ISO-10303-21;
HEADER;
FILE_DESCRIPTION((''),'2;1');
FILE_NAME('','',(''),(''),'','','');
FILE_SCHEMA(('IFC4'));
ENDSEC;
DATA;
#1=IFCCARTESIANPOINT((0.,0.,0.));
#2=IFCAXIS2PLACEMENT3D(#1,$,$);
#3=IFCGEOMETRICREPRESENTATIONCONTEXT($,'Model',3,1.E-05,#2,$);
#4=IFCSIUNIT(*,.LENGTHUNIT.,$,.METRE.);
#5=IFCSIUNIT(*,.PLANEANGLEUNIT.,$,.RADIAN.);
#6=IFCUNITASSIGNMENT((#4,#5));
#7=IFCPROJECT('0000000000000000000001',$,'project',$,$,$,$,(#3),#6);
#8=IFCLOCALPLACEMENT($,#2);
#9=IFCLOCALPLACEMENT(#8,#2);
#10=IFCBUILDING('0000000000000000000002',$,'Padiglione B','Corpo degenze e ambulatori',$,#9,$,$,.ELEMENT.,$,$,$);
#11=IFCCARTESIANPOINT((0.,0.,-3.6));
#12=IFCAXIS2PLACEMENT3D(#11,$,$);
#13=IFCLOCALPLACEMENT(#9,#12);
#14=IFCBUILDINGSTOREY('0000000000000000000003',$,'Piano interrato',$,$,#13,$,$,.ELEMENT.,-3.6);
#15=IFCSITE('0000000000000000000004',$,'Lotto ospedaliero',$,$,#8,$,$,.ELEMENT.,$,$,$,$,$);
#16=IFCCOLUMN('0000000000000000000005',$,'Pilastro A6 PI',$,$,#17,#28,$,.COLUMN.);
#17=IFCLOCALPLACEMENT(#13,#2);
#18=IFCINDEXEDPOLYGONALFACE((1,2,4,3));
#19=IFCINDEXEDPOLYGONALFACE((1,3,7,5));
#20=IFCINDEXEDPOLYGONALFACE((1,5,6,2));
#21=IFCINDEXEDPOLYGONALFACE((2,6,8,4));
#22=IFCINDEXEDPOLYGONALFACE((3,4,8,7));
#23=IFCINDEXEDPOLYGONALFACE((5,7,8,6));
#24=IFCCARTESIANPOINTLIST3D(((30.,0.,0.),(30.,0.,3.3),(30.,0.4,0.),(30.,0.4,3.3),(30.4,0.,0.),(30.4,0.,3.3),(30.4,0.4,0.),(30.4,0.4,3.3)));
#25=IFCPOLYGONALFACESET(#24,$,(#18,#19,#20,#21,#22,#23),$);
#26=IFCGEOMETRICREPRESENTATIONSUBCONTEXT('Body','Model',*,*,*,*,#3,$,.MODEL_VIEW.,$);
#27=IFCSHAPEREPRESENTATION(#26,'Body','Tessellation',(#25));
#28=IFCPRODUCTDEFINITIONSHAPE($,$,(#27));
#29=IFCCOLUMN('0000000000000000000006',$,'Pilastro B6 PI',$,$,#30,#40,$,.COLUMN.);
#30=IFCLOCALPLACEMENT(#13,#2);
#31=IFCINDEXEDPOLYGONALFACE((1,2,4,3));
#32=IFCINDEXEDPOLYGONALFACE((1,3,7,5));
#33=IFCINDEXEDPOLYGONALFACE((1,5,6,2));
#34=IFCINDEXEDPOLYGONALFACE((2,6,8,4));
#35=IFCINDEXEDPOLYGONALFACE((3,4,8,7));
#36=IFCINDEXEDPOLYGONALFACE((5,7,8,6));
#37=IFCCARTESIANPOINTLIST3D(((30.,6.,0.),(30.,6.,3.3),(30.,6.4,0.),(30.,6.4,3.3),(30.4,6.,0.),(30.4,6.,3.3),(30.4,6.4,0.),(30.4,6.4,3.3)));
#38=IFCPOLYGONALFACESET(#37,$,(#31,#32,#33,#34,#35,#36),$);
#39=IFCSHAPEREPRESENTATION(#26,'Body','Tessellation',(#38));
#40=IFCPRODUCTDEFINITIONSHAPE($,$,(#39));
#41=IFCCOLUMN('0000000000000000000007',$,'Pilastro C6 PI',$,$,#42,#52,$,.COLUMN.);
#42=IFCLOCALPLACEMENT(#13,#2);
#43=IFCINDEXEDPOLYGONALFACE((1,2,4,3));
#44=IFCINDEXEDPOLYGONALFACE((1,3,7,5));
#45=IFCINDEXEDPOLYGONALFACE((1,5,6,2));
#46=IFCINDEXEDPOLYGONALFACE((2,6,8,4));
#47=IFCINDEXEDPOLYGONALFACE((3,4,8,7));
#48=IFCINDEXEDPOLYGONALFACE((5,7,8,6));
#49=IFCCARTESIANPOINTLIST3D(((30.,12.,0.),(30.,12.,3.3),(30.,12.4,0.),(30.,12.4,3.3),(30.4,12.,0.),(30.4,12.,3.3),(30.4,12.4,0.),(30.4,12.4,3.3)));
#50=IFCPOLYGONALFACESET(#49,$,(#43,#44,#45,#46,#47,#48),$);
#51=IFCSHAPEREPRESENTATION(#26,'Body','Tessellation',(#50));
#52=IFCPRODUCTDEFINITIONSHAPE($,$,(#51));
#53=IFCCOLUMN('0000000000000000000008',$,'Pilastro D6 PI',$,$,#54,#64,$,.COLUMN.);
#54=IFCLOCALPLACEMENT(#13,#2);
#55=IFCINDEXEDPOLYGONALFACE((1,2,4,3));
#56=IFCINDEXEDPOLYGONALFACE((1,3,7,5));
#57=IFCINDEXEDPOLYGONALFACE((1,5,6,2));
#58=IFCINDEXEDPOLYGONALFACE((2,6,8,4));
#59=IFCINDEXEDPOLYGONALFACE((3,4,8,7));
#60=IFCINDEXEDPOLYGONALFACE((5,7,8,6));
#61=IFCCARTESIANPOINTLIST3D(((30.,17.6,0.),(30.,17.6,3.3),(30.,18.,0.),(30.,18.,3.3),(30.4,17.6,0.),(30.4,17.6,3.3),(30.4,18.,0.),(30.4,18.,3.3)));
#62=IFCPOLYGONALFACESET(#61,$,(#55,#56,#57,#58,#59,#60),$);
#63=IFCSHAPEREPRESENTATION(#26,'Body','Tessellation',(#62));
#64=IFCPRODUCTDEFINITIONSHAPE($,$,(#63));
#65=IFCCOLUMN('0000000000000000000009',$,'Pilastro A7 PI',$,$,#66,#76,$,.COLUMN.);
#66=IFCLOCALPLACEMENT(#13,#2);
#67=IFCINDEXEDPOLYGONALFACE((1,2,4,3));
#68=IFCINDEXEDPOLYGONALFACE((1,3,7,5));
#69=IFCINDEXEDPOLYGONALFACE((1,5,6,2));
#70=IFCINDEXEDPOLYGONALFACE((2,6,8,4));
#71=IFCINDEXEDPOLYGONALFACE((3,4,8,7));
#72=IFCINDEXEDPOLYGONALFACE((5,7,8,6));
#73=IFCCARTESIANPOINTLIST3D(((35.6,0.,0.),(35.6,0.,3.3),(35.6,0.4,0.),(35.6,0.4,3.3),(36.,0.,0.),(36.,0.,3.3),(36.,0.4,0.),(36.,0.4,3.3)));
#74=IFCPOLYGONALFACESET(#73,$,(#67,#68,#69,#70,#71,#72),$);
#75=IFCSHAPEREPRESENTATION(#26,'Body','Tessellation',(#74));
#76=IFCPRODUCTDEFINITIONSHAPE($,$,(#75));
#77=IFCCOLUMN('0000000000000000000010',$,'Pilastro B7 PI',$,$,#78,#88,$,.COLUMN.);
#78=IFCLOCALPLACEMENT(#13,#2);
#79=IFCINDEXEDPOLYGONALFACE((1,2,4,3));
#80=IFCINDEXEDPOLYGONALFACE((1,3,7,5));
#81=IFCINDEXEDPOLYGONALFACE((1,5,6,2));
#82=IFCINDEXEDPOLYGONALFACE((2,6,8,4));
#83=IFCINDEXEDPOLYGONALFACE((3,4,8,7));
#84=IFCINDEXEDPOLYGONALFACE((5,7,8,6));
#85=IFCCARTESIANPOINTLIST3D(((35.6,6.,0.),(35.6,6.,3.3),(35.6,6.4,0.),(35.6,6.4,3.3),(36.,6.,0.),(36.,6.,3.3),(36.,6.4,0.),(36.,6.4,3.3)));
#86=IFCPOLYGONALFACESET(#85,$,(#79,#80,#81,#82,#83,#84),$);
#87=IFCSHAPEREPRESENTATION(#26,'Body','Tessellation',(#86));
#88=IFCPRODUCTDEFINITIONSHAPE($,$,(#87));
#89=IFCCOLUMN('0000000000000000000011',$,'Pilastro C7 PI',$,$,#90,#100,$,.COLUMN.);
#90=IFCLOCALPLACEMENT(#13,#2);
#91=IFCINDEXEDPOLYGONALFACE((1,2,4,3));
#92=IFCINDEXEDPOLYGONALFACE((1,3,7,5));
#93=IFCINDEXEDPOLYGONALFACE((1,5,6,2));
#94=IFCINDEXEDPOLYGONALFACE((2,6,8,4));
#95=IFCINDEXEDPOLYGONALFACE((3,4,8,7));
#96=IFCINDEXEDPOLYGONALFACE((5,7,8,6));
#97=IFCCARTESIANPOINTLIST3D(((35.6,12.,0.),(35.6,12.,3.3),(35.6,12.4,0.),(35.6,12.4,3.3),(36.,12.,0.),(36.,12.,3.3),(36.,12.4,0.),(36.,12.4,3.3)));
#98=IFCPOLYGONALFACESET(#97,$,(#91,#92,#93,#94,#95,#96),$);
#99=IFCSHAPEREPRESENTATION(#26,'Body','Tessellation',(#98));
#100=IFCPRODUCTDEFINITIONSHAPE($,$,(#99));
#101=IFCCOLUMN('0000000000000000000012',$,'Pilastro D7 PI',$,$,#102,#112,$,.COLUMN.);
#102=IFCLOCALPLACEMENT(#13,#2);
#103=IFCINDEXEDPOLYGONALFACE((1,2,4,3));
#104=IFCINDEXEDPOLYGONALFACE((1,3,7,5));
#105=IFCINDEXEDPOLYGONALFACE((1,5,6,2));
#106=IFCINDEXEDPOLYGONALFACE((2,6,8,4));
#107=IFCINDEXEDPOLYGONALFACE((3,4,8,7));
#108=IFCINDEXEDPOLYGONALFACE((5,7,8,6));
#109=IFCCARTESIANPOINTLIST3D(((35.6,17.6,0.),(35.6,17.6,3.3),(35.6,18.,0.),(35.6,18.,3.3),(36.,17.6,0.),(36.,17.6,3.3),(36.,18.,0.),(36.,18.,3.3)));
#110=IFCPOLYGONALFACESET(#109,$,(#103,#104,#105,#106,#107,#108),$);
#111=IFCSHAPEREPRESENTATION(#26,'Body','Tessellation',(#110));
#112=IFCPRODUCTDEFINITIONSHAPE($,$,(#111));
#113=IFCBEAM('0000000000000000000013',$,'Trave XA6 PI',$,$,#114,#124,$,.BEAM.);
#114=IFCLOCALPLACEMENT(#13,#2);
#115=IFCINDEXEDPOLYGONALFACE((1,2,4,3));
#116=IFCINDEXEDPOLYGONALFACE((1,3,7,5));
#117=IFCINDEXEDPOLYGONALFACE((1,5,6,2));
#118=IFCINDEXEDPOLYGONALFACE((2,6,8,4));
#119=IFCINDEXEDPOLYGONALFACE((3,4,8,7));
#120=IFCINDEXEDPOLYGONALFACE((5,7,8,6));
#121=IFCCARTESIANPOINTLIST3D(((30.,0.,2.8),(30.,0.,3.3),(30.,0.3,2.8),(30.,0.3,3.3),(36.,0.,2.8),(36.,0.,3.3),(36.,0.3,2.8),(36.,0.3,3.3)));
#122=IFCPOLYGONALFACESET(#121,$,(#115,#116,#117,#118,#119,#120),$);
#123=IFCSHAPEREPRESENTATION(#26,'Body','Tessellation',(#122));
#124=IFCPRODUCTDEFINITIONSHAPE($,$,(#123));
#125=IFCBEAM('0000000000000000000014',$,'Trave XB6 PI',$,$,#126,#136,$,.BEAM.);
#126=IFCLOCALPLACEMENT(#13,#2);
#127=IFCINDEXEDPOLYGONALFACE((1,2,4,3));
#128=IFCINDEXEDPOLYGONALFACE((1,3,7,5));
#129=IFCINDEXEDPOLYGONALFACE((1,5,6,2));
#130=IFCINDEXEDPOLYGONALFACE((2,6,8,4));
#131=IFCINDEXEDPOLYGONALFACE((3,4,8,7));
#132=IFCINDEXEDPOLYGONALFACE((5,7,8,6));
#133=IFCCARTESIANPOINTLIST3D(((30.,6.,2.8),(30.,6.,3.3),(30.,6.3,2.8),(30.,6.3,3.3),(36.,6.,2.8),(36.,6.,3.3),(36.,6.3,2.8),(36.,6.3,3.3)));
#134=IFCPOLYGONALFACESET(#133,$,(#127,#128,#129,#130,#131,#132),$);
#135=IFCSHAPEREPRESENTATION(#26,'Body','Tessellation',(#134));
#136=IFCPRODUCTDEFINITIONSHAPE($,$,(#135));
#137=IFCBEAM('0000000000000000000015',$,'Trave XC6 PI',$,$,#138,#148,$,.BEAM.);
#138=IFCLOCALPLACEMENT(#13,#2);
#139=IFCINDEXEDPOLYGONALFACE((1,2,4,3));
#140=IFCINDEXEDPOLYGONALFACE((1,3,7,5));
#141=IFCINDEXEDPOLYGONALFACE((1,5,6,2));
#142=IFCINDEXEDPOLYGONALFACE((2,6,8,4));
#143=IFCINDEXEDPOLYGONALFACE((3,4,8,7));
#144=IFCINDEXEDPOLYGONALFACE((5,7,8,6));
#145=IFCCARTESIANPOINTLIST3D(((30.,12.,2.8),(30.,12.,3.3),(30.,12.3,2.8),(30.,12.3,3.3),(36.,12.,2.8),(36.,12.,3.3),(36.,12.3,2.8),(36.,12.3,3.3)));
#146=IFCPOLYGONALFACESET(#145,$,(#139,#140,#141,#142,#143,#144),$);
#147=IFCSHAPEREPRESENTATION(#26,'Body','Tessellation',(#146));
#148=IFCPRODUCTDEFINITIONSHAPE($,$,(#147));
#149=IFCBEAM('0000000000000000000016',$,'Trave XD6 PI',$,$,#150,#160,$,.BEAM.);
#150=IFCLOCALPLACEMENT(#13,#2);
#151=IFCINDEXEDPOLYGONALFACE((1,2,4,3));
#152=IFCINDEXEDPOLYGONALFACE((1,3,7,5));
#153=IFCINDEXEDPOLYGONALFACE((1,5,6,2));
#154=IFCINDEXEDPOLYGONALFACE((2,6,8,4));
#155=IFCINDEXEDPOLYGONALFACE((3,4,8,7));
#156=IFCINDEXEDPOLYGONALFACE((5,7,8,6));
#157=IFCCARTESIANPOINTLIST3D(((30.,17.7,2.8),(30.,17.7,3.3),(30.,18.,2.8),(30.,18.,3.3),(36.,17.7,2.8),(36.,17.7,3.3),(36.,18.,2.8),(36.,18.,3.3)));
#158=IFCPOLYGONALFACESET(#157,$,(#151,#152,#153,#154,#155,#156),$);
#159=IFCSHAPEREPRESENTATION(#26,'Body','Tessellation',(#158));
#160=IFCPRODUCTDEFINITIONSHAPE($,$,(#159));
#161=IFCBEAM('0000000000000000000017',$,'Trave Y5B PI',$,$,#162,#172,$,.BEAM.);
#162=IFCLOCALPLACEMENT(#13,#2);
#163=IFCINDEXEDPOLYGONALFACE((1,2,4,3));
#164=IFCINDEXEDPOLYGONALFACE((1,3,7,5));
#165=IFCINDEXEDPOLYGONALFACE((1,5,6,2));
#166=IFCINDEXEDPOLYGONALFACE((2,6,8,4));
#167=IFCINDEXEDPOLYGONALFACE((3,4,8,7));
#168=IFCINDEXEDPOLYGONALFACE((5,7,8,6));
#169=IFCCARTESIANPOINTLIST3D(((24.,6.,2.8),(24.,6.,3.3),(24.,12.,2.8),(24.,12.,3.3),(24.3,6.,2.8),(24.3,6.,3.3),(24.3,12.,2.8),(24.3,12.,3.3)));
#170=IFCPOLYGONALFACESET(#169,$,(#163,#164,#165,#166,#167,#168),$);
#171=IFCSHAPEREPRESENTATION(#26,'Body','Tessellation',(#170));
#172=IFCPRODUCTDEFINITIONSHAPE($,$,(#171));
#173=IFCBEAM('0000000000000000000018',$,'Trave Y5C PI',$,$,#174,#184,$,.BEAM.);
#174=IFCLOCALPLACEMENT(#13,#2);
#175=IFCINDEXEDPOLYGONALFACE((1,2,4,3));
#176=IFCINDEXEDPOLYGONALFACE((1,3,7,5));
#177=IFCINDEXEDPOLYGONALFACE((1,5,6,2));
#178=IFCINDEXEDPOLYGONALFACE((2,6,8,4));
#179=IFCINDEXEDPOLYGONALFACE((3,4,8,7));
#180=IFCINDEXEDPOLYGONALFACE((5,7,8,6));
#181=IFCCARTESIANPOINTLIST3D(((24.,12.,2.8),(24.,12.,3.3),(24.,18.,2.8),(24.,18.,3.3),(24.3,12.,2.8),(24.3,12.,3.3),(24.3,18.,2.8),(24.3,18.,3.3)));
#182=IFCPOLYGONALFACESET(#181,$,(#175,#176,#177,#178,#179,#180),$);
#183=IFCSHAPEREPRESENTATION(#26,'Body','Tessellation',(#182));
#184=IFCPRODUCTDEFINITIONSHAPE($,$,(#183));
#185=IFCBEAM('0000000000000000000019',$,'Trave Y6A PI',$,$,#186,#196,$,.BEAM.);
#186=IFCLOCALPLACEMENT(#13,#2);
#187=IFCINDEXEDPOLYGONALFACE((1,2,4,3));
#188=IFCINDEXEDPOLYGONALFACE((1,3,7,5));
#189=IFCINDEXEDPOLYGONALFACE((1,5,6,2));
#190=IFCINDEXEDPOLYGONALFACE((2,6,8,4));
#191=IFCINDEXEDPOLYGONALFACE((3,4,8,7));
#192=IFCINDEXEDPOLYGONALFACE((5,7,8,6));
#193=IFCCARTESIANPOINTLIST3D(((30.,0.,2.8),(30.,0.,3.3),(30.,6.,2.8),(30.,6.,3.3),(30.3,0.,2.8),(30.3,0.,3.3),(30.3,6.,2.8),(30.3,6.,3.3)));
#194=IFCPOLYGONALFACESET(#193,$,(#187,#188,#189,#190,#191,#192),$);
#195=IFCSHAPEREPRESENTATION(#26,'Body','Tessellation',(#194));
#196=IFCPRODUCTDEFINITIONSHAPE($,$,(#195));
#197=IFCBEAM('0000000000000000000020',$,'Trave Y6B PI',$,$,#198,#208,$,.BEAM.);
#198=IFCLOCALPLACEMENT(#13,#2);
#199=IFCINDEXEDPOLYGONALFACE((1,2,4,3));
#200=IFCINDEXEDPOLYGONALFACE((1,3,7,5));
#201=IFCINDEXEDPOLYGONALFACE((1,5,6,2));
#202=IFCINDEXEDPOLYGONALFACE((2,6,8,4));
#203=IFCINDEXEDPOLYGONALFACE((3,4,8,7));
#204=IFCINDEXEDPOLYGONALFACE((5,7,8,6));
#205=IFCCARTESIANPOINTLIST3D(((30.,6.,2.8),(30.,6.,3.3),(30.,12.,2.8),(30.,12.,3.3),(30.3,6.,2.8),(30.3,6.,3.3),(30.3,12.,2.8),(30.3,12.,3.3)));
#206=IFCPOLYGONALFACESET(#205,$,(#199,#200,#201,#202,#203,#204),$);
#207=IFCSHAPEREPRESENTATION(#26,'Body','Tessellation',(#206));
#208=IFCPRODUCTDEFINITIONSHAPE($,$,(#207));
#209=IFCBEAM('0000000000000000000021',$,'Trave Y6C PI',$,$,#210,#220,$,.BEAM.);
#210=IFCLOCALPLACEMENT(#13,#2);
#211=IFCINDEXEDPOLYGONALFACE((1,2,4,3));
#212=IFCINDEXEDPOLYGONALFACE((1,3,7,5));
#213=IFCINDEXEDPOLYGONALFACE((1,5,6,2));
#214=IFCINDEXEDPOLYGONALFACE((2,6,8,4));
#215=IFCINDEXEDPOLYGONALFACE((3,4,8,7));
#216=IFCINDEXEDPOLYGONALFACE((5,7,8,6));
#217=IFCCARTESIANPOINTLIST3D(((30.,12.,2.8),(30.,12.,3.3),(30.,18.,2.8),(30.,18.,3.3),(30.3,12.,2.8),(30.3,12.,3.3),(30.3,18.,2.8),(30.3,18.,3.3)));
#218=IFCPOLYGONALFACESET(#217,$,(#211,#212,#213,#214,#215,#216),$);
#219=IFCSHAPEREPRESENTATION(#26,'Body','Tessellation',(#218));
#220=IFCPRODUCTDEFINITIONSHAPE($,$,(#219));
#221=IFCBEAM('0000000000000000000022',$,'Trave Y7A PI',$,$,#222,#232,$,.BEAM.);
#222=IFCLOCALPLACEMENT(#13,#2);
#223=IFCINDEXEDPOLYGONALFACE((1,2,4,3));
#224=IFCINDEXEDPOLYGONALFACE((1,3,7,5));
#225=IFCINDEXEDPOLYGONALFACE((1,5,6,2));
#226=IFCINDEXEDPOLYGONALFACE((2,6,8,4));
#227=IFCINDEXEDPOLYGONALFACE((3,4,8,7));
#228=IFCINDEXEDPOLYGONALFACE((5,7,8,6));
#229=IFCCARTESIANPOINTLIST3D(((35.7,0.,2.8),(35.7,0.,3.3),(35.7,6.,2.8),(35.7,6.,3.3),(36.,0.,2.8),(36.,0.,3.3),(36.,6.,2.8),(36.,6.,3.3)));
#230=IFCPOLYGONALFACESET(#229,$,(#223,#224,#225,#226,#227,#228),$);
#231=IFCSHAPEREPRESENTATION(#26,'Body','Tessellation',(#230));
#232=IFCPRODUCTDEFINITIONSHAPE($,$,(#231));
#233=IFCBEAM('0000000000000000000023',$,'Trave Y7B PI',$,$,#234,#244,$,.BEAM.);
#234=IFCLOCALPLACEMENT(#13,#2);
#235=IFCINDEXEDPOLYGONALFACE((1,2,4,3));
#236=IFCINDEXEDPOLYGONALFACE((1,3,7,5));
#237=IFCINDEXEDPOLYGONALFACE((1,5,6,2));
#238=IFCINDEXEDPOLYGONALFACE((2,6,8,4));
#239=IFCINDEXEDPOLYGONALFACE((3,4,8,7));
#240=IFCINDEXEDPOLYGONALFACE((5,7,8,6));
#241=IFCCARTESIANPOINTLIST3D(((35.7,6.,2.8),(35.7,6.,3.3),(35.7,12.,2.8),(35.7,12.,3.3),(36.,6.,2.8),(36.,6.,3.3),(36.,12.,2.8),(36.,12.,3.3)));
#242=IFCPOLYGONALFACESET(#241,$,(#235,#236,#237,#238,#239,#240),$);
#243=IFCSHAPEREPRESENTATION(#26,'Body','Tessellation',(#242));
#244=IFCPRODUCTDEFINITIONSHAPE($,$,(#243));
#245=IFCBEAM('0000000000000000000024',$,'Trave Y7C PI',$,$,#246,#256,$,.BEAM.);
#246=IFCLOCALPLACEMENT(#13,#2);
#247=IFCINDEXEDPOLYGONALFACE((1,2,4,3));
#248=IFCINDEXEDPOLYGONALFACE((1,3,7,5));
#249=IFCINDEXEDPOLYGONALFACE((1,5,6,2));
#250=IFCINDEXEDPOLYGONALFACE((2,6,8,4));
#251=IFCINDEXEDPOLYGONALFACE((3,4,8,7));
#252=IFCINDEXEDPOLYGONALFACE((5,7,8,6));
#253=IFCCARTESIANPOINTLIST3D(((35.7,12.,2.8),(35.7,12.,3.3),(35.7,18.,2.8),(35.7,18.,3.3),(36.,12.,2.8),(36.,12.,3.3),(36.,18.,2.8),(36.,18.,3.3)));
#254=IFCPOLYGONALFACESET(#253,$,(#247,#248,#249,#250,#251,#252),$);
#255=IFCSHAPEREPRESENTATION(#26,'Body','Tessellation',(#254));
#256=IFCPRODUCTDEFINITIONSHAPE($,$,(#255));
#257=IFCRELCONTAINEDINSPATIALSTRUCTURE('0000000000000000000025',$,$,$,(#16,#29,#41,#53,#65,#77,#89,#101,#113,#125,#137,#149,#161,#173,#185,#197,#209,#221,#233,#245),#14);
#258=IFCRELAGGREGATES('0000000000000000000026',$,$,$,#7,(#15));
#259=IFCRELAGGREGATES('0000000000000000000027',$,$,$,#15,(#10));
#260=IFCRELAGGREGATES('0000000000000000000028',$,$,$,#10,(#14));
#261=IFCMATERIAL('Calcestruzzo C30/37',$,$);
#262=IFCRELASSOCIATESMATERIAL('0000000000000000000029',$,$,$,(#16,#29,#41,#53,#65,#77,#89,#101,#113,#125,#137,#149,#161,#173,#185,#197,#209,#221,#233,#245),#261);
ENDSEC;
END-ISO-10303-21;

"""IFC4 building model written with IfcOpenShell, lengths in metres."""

from ifc_helpers import new_model, si_unit, frame, frame_2d, origin, place, context, subcontext, project, spatial, rectangle, extrude, material, element, save


model = new_model("IFC4")

# Units and contexts
model_context = context("Model", 3, precision=1e-05, world=origin())
body_context = subcontext(model_context, "Body", "Model", "MODEL_VIEW")
ifc_project = project(units=[si_unit("LENGTHUNIT", "METRE"), si_unit("PLANEANGLEUNIT", "RADIAN")], contexts=[model_context])

# Site, building, storey
site_placement = place(None, origin())
site = spatial("IfcSite", under=ifc_project, at=site_placement, Name="Lotto ospedaliero", CompositionType="ELEMENT")
building_placement = place(site_placement, origin())
building = spatial("IfcBuilding", under=site, at=building_placement, Name="Padiglione B", Description="Corpo degenze e ambulatori", CompositionType="ELEMENT")
storey_placement = place(building_placement, frame((0.0, 0.0, -3.6)))
storey = spatial("IfcBuildingStorey", under=building, at=storey_placement, Name="Piano interrato", CompositionType="ELEMENT", Elevation=-3.6)

# Columns
ifc_material_1 = material(Name="Calcestruzzo C30/37")
for number, where, name in (
    (1, (30.0, 0.0, 0.0), "Pilastro A6 PI"),
    (2, (30.0, 6.0, 0.0), "Pilastro B6 PI"),
    (3, (30.0, 12.0, 0.0), "Pilastro C6 PI"),
    (4, (30.0, 17.6, 0.0), "Pilastro D6 PI"),
    (5, (35.6, 0.0, 0.0), "Pilastro A7 PI"),
    (6, (35.6, 6.0, 0.0), "Pilastro B7 PI"),
    (7, (35.6, 12.0, 0.0), "Pilastro C7 PI"),
    (8, (35.6, 17.6, 0.0), "Pilastro D7 PI"),
):
    element("IfcColumn", number, at=place(storey_placement, frame(where)), inside=storey, material=ifc_material_1, Name=name, PredefinedType="COLUMN", context=body_context, shape_type="SweptSolid", body=[
        extrude(rectangle(XDim=0.4, YDim=0.4, at=frame_2d((0.2, 0.2))), origin(), (0.0, 0.0, 1.0), 3.3),
    ])

# Beams
for number, where, name in (
    (9, (30.0, 0.0, 2.8), "Trave XA6 PI"),
    (10, (30.0, 6.0, 2.8), "Trave XB6 PI"),
    (11, (30.0, 12.0, 2.8), "Trave XC6 PI"),
    (12, (30.0, 17.7, 2.8), "Trave XD6 PI"),
):
    element("IfcBeam", number, at=place(storey_placement, frame(where)), inside=storey, material=ifc_material_1, Name=name, PredefinedType="BEAM", context=body_context, shape_type="SweptSolid", body=[
        extrude(rectangle(XDim=6.0, YDim=0.3, at=frame_2d((3.0, 0.15))), origin(), (0.0, 0.0, 1.0), 0.5),
    ])
for number, where, name in (
    (13, (24.0, 6.0, 2.8), "Trave Y5B PI"),
    (14, (24.0, 12.0, 2.8), "Trave Y5C PI"),
    (15, (30.0, 0.0, 2.8), "Trave Y6A PI"),
    (16, (30.0, 6.0, 2.8), "Trave Y6B PI"),
    (17, (30.0, 12.0, 2.8), "Trave Y6C PI"),
    (18, (35.7, 0.0, 2.8), "Trave Y7A PI"),
    (19, (35.7, 6.0, 2.8), "Trave Y7B PI"),
    (20, (35.7, 12.0, 2.8), "Trave Y7C PI"),
):
    element("IfcBeam", number, at=place(storey_placement, frame(where)), inside=storey, material=ifc_material_1, Name=name, PredefinedType="BEAM", context=body_context, shape_type="SweptSolid", body=[
        extrude(rectangle(XDim=0.3, YDim=6.0, at=frame_2d((0.15, 3.0))), origin(), (0.0, 0.0, 1.0), 0.5),
    ])

save(model, "model.ifc")
